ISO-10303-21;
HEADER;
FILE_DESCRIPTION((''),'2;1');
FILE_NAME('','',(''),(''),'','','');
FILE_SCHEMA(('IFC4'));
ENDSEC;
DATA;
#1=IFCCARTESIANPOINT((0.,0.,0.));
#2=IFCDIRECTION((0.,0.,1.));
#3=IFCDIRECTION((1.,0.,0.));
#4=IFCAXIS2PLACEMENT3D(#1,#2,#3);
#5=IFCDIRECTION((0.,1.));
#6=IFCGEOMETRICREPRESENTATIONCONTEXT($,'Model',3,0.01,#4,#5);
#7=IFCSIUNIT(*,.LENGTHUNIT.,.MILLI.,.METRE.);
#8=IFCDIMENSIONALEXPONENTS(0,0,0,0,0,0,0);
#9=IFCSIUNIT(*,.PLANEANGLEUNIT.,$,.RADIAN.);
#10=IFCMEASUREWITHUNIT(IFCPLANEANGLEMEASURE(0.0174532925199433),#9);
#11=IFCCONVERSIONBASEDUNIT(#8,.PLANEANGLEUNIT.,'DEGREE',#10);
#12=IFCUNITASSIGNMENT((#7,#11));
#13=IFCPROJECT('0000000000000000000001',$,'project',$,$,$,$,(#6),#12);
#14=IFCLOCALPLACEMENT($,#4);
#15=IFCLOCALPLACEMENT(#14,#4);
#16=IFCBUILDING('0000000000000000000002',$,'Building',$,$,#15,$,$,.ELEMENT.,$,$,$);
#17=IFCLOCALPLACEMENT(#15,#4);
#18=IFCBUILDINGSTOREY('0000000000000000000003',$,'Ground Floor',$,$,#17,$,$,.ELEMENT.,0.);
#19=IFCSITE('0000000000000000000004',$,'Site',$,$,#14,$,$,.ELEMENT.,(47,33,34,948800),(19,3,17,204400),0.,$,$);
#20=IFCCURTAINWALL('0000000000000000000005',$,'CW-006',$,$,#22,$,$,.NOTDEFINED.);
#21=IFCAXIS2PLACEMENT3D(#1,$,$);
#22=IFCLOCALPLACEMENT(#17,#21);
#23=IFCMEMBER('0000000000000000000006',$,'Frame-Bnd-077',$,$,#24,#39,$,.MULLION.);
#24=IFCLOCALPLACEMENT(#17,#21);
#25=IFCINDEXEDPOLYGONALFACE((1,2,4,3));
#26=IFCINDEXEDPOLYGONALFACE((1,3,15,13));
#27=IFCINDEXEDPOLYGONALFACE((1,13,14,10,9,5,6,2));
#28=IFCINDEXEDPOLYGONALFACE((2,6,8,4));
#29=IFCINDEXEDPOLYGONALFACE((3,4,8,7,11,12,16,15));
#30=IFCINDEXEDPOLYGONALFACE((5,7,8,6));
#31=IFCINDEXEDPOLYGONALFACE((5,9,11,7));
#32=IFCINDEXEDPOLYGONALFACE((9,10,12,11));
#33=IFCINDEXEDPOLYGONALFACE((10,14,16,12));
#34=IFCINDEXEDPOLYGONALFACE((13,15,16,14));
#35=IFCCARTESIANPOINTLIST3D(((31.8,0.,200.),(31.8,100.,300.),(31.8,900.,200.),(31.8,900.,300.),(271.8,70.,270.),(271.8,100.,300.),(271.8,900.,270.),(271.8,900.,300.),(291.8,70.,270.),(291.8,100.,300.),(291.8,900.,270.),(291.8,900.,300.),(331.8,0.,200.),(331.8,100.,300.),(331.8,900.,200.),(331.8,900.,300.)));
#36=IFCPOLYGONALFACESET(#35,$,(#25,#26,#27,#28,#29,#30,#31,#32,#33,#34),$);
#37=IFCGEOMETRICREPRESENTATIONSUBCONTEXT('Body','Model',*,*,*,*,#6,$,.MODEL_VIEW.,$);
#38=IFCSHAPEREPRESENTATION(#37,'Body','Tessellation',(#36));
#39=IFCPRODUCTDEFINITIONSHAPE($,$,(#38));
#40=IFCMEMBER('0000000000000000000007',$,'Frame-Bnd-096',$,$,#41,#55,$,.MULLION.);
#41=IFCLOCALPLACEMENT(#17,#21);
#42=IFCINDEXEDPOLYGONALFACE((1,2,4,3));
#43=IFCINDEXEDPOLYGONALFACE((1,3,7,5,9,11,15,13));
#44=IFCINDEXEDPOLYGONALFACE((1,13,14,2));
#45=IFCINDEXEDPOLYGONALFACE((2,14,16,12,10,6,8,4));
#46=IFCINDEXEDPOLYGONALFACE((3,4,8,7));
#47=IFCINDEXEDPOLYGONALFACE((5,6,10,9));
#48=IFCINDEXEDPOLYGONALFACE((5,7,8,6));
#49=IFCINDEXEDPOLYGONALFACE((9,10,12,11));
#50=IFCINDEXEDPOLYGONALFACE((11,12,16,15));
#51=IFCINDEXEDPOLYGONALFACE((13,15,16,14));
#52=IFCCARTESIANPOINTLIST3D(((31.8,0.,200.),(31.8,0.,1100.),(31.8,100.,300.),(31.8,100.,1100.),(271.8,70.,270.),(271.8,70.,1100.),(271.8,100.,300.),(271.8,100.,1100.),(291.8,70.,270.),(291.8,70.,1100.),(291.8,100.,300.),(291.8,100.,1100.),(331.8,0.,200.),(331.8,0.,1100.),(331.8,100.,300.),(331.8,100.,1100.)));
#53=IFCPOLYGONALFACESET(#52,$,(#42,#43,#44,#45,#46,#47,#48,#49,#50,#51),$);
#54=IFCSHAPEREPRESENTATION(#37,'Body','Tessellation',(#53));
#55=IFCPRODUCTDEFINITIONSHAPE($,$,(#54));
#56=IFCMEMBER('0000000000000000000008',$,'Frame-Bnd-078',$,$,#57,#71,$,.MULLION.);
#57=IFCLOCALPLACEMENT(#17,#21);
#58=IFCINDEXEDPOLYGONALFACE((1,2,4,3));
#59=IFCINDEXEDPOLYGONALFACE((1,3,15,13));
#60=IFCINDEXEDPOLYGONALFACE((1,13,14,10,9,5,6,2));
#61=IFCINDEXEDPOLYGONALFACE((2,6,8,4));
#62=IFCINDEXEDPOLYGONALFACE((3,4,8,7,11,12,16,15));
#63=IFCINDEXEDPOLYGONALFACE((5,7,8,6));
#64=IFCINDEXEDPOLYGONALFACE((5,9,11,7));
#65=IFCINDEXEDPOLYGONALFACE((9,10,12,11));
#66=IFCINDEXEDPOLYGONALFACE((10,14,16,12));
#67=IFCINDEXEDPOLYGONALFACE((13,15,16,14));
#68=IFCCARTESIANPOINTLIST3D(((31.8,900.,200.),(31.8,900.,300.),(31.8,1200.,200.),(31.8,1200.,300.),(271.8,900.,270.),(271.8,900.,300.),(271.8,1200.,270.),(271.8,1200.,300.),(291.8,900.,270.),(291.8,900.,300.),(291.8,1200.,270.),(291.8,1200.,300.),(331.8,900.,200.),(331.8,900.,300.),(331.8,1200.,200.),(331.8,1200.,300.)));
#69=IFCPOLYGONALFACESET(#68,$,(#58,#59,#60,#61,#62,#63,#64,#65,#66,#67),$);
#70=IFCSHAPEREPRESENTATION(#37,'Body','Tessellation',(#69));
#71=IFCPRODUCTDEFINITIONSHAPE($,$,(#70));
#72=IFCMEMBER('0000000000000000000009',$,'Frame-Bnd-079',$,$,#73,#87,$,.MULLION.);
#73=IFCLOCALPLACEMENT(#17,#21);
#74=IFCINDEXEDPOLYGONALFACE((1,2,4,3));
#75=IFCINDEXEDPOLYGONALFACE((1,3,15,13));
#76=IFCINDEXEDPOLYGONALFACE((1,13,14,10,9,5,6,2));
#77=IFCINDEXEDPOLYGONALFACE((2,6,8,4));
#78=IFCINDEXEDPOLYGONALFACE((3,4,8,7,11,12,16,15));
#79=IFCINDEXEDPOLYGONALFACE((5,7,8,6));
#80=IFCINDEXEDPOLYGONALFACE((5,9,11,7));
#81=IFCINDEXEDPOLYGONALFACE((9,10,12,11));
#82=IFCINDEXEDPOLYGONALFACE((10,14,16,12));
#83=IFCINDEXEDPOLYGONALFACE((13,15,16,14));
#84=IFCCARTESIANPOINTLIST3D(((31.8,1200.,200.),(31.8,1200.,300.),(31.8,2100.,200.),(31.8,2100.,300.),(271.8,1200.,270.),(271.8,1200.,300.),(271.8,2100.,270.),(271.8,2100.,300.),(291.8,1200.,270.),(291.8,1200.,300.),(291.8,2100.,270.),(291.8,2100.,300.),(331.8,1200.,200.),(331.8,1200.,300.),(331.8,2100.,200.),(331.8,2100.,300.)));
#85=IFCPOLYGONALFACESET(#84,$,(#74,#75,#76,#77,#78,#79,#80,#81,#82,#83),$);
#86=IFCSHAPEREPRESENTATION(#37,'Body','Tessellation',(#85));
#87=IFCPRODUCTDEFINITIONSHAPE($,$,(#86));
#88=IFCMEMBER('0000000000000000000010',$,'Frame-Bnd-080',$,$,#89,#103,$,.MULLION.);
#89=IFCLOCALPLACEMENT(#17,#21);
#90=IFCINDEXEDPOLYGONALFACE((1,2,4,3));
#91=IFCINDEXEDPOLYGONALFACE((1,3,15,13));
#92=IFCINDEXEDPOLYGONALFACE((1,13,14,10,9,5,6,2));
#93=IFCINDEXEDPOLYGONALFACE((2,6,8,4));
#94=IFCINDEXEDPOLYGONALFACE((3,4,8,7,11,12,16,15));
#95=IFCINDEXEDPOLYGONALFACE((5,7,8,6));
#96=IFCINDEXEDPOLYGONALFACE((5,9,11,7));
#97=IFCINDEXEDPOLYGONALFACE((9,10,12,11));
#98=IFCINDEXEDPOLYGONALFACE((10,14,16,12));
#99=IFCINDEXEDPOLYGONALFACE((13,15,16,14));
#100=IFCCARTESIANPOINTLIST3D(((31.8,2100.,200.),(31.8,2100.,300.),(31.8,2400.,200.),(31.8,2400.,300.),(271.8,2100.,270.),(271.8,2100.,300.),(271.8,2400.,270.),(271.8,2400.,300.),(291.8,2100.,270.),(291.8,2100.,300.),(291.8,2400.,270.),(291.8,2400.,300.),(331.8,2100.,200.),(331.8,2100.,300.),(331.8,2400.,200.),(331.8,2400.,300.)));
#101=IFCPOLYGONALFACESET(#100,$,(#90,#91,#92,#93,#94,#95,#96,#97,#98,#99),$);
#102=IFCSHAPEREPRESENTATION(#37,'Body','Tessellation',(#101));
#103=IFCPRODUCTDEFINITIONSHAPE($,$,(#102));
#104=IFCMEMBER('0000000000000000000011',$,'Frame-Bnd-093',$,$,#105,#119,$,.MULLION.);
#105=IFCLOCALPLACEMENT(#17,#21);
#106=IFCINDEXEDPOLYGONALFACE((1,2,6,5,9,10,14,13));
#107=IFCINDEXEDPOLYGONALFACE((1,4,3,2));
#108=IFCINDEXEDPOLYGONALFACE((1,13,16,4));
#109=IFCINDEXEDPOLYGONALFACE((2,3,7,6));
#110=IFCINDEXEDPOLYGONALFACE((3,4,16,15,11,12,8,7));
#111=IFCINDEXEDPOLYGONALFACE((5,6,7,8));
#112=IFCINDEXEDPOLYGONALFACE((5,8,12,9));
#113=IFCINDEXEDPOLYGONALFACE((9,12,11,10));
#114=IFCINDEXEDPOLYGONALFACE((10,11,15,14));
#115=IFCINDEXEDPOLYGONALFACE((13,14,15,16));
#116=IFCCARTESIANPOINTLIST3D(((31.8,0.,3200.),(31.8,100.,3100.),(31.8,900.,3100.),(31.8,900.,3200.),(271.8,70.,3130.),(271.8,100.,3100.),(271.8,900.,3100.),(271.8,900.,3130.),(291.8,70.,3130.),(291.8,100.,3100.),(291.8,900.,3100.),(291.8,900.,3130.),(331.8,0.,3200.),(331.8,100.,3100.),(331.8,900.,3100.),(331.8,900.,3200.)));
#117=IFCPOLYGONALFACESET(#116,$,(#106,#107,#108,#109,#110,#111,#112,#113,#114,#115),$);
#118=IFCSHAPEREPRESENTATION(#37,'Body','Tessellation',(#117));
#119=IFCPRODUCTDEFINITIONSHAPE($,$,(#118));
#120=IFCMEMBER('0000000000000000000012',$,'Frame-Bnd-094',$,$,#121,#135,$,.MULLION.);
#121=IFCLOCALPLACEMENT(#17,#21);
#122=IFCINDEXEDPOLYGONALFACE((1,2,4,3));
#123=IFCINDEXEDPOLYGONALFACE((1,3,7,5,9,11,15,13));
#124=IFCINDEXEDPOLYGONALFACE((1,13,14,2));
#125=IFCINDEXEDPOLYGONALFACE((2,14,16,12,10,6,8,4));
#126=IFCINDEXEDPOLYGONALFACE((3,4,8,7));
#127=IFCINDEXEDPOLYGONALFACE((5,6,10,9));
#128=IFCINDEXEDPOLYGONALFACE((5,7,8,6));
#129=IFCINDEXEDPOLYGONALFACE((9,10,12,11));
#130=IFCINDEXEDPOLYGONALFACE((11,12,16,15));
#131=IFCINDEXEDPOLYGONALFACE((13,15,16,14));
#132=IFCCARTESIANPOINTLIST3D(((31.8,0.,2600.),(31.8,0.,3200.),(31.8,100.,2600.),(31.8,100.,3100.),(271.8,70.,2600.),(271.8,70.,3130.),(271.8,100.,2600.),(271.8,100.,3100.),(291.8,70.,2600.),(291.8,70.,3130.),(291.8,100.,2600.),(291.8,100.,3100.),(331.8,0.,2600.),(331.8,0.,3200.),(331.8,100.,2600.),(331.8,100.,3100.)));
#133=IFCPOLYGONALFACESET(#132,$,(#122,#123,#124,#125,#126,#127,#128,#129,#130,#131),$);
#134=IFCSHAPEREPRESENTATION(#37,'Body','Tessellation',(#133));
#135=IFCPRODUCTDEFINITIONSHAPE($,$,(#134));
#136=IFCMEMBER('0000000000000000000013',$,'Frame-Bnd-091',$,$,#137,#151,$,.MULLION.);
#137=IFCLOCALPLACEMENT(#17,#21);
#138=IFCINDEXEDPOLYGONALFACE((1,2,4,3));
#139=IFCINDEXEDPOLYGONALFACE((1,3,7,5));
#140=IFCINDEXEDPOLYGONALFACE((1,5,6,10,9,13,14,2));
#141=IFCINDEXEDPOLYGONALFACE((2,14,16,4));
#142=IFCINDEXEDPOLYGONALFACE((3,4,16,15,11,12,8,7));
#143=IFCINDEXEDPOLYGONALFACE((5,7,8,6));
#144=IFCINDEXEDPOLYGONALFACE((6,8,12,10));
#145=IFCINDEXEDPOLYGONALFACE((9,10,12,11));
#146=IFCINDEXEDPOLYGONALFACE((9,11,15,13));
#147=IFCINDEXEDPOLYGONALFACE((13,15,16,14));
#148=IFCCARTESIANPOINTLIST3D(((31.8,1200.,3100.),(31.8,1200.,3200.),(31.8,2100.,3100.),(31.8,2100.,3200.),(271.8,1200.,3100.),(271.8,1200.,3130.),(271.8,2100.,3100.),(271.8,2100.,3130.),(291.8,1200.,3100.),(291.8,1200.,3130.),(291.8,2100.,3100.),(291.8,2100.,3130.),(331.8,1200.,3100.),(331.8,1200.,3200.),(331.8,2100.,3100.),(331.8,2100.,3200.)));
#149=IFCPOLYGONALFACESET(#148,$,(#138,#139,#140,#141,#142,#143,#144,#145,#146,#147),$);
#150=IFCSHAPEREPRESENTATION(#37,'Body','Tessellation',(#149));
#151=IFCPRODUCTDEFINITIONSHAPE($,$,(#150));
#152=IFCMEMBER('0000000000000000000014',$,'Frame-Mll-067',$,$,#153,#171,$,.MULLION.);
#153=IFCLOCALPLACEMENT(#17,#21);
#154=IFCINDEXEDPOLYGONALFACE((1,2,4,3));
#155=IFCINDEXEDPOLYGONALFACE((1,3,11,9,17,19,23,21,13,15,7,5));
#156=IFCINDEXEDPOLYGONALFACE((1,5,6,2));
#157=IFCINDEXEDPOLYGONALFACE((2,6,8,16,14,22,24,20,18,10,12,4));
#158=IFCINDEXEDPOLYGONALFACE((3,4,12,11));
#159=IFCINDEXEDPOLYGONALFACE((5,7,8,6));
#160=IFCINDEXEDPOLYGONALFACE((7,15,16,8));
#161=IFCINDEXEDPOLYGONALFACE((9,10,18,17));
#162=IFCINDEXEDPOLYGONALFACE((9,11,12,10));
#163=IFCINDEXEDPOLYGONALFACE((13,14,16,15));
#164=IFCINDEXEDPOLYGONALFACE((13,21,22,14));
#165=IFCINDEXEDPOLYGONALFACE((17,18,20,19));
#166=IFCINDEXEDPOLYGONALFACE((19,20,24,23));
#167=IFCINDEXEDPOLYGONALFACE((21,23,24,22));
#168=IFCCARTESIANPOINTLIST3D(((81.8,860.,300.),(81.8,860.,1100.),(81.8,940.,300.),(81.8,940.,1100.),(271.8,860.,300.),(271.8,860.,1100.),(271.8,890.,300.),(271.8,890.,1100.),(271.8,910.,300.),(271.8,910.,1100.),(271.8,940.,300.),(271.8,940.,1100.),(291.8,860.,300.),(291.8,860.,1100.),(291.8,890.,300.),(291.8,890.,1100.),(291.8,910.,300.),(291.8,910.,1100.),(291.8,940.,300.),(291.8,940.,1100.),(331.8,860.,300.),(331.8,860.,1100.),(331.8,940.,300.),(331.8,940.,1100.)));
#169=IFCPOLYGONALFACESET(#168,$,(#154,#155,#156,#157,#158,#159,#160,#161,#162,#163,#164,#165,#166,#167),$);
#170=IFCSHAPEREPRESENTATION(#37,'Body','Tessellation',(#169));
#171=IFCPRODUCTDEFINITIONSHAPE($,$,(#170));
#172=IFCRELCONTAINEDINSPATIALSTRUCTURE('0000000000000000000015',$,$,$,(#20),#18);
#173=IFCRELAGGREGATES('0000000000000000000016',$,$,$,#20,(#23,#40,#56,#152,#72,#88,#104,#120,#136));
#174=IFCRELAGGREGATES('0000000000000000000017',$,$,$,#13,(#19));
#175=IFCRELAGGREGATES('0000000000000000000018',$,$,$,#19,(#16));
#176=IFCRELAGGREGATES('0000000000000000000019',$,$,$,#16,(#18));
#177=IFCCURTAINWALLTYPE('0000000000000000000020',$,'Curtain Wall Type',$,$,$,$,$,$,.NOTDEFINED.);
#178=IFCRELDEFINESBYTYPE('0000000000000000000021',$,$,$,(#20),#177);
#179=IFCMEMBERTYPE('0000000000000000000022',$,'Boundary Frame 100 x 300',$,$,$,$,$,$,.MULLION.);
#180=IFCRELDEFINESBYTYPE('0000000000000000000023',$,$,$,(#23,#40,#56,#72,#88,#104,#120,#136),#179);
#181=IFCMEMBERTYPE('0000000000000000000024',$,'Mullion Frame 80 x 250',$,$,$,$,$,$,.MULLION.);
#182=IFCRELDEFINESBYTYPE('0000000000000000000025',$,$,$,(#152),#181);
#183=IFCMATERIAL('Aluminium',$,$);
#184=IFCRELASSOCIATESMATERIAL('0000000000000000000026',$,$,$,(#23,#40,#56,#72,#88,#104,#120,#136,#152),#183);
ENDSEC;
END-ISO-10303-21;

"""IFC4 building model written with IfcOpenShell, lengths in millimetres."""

from ifc_helpers import new_model, entity, si_unit, converted_unit, direction, frame, origin_with_axes, place, context, subcontext, project, spatial, line, indexed_curve, outline, extrude, clip, halfspace, material, type_object, element, aggregate, save


model = new_model("IFC4")

# Units and contexts
model_context = context("Model", 3, precision=0.01, world=origin_with_axes(), true_north=direction((0.0, 1.0)))
body_context = subcontext(model_context, "Body", "Model", "MODEL_VIEW")
ifc_project = project(units=[si_unit("LENGTHUNIT", "METRE", prefix="MILLI"), converted_unit("PLANEANGLEUNIT", "DEGREE", entity("IfcPlaneAngleMeasure", 0.0174532925199433), si_unit("PLANEANGLEUNIT", "RADIAN"), dimensions=[0, 0, 0, 0, 0, 0, 0])], contexts=[model_context])

# Site, building, storey
site_placement = place(None, origin_with_axes())
site = spatial("IfcSite", under=ifc_project, at=site_placement, Name="Site", CompositionType="ELEMENT", RefLatitude=(47, 33, 34, 948800), RefLongitude=(19, 3, 17, 204400), RefElevation=0.0)
building_placement = place(site_placement, origin_with_axes())
building = spatial("IfcBuilding", under=site, at=building_placement, Name="Building", CompositionType="ELEMENT")
storey_placement = place(building_placement, origin_with_axes())
storey = spatial("IfcBuildingStorey", under=building, at=storey_placement, Name="Ground Floor", CompositionType="ELEMENT", Elevation=0.0)

# Curtain wall, members
curtain_wall_type = type_object("IfcCurtainWallType", Name="Curtain Wall Type", PredefinedType="NOTDEFINED")
curtain_wall_placement = place(storey_placement, frame((281.8, 450.0, 200.0), z_axis=(0.0, 0.0, 1.0), x_axis=(1.0, 0.0, 0.0)))
curtain_wall = element("IfcCurtainWall", 1, at=curtain_wall_placement, inside=storey, type_object=curtain_wall_type, Name="CW-006", PredefinedType="NOTDEFINED")
ifc_material_1 = material(Name="Aluminium")
member_type_1 = type_object("IfcMemberType", Name="Boundary Frame 100 x 300", PredefinedType="MULLION")
member_1_placement = place(curtain_wall_placement, frame((0.0, -450.0, 0.0), z_axis=(0.0, 1.0, 0.0), x_axis=(0.0, 0.0, 1.0)))
member_1 = element("IfcMember", 2, at=member_1_placement, type_object=member_type_1, material=ifc_material_1, Name="Frame-Bnd-077", PredefinedType="MULLION", context=body_context, shape_type="Clipping", body=[
    clip(extrude(outline(indexed_curve([(70.0, -10.0), (70.0, 10.0), (100.0, 10.0), (100.0, 50.0), (0.0, 50.0), (0.0, -250.0), (100.0, -250.0), (100.0, -10.0)], segments=[line(1, 2, 3, 4, 5, 6, 7, 8, 1)])), origin_with_axes(), (0.0, 0.0, 1.0), 900.0), halfspace(frame((0.0, 0.0, 0.0), z_axis=(-0.707107, 0.0, 0.707107), x_axis=(0.0, -1.0, 0.0)), True)),
])
member_2_placement = place(curtain_wall_placement, frame((0.0, -450.0, 0.0), z_axis=(0.0, 0.0, 1.0), x_axis=(0.0, -1.0, 0.0)))
member_2 = element("IfcMember", 3, at=member_2_placement, type_object=member_type_1, material=ifc_material_1, Name="Frame-Bnd-096", PredefinedType="MULLION", context=body_context, shape_type="Clipping", body=[
    clip(extrude(outline(indexed_curve([(-70.0, -10.0), (-100.0, -10.0), (-100.0, -250.0), (0.0, -250.0), (0.0, 50.0), (-100.0, 50.0), (-100.0, 10.0), (-70.0, 10.0)], segments=[line(1, 2, 3, 4, 5, 6, 7, 8, 1)])), origin_with_axes(), (0.0, 0.0, 1.0), 900.0), halfspace(frame((0.0, 0.0, 0.0), z_axis=(0.707107, 0.0, 0.707107), x_axis=(0.0, -1.0, 0.0)), True)),
])
member_3_placement = place(curtain_wall_placement, frame((0.0, 450.0, 0.0), z_axis=(0.0, 1.0, 0.0), x_axis=(0.0, 0.0, 1.0)))
member_3 = element("IfcMember", 4, at=member_3_placement, type_object=member_type_1, material=ifc_material_1, Name="Frame-Bnd-078", PredefinedType="MULLION", context=body_context, shape_type="SweptSolid", body=[
    extrude(outline(indexed_curve([(70.0, -10.0), (70.0, 10.0), (100.0, 10.0), (100.0, 50.0), (0.0, 50.0), (0.0, -250.0), (100.0, -250.0), (100.0, -10.0)], segments=[line(1, 2, 3, 4, 5, 6, 7, 8, 1)])), origin_with_axes(), (0.0, 0.0, 1.0), 300.0),
])
member_4_placement = place(curtain_wall_placement, frame((0.0, 750.0, 0.0), z_axis=(0.0, 1.0, 0.0), x_axis=(0.0, 0.0, 1.0)))
member_4 = element("IfcMember", 5, at=member_4_placement, type_object=member_type_1, material=ifc_material_1, Name="Frame-Bnd-079", PredefinedType="MULLION", context=body_context, shape_type="SweptSolid", body=[
    extrude(outline(indexed_curve([(70.0, -10.0), (70.0, 10.0), (100.0, 10.0), (100.0, 50.0), (0.0, 50.0), (0.0, -250.0), (100.0, -250.0), (100.0, -10.0)], segments=[line(1, 2, 3, 4, 5, 6, 7, 8, 1)])), origin_with_axes(), (0.0, 0.0, 1.0), 900.0),
])
member_5_placement = place(curtain_wall_placement, frame((0.0, 1650.0, 0.0), z_axis=(0.0, 1.0, 0.0), x_axis=(0.0, 0.0, 1.0)))
member_5 = element("IfcMember", 6, at=member_5_placement, type_object=member_type_1, material=ifc_material_1, Name="Frame-Bnd-080", PredefinedType="MULLION", context=body_context, shape_type="SweptSolid", body=[
    extrude(outline(indexed_curve([(70.0, -10.0), (70.0, 10.0), (100.0, 10.0), (100.0, 50.0), (0.0, 50.0), (0.0, -250.0), (100.0, -250.0), (100.0, -10.0)], segments=[line(1, 2, 3, 4, 5, 6, 7, 8, 1)])), origin_with_axes(), (0.0, 0.0, 1.0), 300.0),
])
member_6_placement = place(curtain_wall_placement, frame((0.0, -450.0, 3000.0), z_axis=(0.0, 1.0, 0.0), x_axis=(0.0, 0.0, 1.0)))
member_6 = element("IfcMember", 7, at=member_6_placement, type_object=member_type_1, material=ifc_material_1, Name="Frame-Bnd-093", PredefinedType="MULLION", context=body_context, shape_type="Clipping", body=[
    clip(extrude(outline(indexed_curve([(-70.0, -10.0), (-100.0, -10.0), (-100.0, -250.0), (0.0, -250.0), (0.0, 50.0), (-100.0, 50.0), (-100.0, 10.0), (-70.0, 10.0)], segments=[line(1, 2, 3, 4, 5, 6, 7, 8, 1)])), origin_with_axes(), (0.0, 0.0, 1.0), 900.0), halfspace(frame((0.0, 0.0, 0.0), z_axis=(0.707107, 0.0, 0.707107), x_axis=(0.0, -1.0, 0.0)), True)),
])
member_7_placement = place(curtain_wall_placement, frame((0.0, -450.0, 2400.0), z_axis=(0.0, 0.0, 1.0), x_axis=(0.0, -1.0, 0.0)))
member_7 = element("IfcMember", 8, at=member_7_placement, type_object=member_type_1, material=ifc_material_1, Name="Frame-Bnd-094", PredefinedType="MULLION", context=body_context, shape_type="Clipping", body=[
    clip(extrude(outline(indexed_curve([(-70.0, -10.0), (-100.0, -10.0), (-100.0, -250.0), (0.0, -250.0), (0.0, 50.0), (-100.0, 50.0), (-100.0, 10.0), (-70.0, 10.0)], segments=[line(1, 2, 3, 4, 5, 6, 7, 8, 1)])), origin_with_axes(), (0.0, 0.0, 1.0), 600.0), halfspace(frame((-300.0, 0.0, 300.0), z_axis=(0.707107, 0.0, -0.707107), x_axis=(0.0, 1.0, 0.0)), True)),
])
member_8_placement = place(curtain_wall_placement, frame((0.0, 750.0, 3000.0), z_axis=(0.0, 1.0, 0.0), x_axis=(0.0, 0.0, 1.0)))
member_8 = element("IfcMember", 9, at=member_8_placement, type_object=member_type_1, material=ifc_material_1, Name="Frame-Bnd-091", PredefinedType="MULLION", context=body_context, shape_type="SweptSolid", body=[
    extrude(outline(indexed_curve([(-70.0, -10.0), (-100.0, -10.0), (-100.0, -250.0), (0.0, -250.0), (0.0, 50.0), (-100.0, 50.0), (-100.0, 10.0), (-70.0, 10.0)], segments=[line(1, 2, 3, 4, 5, 6, 7, 8, 1)])), origin_with_axes(), (0.0, 0.0, 1.0), 900.0),
])
member_type_2 = type_object("IfcMemberType", Name="Mullion Frame 80 x 250", PredefinedType="MULLION")
member_9_placement = place(curtain_wall_placement, frame((0.0, 450.0, 0.0), z_axis=(0.0, 0.0, 1.0), x_axis=(0.0, -1.0, 0.0)))
member_9 = element("IfcMember", 10, at=member_9_placement, type_object=member_type_2, material=ifc_material_1, Name="Frame-Mll-067", PredefinedType="MULLION", context=body_context, shape_type="SweptSolid", body=[
    extrude(outline(indexed_curve([(-10.0, -10.0), (-40.0, -10.0), (-40.0, -200.0), (40.0, -200.0), (40.0, -10.0), (10.0, -10.0), (10.0, 10.0), (40.0, 10.0), (40.0, 50.0), (-40.0, 50.0), (-40.0, 10.0), (-10.0, 10.0)], segments=[line(1, 2, 3, 4, 5, 6, 7, 8, 9, 10, 11, 12, 1)])), frame((0.0, 0.0, 100.0), z_axis=(0.0, 0.0, 1.0), x_axis=(1.0, 0.0, 0.0)), (0.0, 0.0, 1.0), 800.0),
])

aggregate(curtain_wall, [member_1, member_2, member_3, member_9, member_4, member_5, member_6, member_7, member_8])

save(model, "model.ifc")
